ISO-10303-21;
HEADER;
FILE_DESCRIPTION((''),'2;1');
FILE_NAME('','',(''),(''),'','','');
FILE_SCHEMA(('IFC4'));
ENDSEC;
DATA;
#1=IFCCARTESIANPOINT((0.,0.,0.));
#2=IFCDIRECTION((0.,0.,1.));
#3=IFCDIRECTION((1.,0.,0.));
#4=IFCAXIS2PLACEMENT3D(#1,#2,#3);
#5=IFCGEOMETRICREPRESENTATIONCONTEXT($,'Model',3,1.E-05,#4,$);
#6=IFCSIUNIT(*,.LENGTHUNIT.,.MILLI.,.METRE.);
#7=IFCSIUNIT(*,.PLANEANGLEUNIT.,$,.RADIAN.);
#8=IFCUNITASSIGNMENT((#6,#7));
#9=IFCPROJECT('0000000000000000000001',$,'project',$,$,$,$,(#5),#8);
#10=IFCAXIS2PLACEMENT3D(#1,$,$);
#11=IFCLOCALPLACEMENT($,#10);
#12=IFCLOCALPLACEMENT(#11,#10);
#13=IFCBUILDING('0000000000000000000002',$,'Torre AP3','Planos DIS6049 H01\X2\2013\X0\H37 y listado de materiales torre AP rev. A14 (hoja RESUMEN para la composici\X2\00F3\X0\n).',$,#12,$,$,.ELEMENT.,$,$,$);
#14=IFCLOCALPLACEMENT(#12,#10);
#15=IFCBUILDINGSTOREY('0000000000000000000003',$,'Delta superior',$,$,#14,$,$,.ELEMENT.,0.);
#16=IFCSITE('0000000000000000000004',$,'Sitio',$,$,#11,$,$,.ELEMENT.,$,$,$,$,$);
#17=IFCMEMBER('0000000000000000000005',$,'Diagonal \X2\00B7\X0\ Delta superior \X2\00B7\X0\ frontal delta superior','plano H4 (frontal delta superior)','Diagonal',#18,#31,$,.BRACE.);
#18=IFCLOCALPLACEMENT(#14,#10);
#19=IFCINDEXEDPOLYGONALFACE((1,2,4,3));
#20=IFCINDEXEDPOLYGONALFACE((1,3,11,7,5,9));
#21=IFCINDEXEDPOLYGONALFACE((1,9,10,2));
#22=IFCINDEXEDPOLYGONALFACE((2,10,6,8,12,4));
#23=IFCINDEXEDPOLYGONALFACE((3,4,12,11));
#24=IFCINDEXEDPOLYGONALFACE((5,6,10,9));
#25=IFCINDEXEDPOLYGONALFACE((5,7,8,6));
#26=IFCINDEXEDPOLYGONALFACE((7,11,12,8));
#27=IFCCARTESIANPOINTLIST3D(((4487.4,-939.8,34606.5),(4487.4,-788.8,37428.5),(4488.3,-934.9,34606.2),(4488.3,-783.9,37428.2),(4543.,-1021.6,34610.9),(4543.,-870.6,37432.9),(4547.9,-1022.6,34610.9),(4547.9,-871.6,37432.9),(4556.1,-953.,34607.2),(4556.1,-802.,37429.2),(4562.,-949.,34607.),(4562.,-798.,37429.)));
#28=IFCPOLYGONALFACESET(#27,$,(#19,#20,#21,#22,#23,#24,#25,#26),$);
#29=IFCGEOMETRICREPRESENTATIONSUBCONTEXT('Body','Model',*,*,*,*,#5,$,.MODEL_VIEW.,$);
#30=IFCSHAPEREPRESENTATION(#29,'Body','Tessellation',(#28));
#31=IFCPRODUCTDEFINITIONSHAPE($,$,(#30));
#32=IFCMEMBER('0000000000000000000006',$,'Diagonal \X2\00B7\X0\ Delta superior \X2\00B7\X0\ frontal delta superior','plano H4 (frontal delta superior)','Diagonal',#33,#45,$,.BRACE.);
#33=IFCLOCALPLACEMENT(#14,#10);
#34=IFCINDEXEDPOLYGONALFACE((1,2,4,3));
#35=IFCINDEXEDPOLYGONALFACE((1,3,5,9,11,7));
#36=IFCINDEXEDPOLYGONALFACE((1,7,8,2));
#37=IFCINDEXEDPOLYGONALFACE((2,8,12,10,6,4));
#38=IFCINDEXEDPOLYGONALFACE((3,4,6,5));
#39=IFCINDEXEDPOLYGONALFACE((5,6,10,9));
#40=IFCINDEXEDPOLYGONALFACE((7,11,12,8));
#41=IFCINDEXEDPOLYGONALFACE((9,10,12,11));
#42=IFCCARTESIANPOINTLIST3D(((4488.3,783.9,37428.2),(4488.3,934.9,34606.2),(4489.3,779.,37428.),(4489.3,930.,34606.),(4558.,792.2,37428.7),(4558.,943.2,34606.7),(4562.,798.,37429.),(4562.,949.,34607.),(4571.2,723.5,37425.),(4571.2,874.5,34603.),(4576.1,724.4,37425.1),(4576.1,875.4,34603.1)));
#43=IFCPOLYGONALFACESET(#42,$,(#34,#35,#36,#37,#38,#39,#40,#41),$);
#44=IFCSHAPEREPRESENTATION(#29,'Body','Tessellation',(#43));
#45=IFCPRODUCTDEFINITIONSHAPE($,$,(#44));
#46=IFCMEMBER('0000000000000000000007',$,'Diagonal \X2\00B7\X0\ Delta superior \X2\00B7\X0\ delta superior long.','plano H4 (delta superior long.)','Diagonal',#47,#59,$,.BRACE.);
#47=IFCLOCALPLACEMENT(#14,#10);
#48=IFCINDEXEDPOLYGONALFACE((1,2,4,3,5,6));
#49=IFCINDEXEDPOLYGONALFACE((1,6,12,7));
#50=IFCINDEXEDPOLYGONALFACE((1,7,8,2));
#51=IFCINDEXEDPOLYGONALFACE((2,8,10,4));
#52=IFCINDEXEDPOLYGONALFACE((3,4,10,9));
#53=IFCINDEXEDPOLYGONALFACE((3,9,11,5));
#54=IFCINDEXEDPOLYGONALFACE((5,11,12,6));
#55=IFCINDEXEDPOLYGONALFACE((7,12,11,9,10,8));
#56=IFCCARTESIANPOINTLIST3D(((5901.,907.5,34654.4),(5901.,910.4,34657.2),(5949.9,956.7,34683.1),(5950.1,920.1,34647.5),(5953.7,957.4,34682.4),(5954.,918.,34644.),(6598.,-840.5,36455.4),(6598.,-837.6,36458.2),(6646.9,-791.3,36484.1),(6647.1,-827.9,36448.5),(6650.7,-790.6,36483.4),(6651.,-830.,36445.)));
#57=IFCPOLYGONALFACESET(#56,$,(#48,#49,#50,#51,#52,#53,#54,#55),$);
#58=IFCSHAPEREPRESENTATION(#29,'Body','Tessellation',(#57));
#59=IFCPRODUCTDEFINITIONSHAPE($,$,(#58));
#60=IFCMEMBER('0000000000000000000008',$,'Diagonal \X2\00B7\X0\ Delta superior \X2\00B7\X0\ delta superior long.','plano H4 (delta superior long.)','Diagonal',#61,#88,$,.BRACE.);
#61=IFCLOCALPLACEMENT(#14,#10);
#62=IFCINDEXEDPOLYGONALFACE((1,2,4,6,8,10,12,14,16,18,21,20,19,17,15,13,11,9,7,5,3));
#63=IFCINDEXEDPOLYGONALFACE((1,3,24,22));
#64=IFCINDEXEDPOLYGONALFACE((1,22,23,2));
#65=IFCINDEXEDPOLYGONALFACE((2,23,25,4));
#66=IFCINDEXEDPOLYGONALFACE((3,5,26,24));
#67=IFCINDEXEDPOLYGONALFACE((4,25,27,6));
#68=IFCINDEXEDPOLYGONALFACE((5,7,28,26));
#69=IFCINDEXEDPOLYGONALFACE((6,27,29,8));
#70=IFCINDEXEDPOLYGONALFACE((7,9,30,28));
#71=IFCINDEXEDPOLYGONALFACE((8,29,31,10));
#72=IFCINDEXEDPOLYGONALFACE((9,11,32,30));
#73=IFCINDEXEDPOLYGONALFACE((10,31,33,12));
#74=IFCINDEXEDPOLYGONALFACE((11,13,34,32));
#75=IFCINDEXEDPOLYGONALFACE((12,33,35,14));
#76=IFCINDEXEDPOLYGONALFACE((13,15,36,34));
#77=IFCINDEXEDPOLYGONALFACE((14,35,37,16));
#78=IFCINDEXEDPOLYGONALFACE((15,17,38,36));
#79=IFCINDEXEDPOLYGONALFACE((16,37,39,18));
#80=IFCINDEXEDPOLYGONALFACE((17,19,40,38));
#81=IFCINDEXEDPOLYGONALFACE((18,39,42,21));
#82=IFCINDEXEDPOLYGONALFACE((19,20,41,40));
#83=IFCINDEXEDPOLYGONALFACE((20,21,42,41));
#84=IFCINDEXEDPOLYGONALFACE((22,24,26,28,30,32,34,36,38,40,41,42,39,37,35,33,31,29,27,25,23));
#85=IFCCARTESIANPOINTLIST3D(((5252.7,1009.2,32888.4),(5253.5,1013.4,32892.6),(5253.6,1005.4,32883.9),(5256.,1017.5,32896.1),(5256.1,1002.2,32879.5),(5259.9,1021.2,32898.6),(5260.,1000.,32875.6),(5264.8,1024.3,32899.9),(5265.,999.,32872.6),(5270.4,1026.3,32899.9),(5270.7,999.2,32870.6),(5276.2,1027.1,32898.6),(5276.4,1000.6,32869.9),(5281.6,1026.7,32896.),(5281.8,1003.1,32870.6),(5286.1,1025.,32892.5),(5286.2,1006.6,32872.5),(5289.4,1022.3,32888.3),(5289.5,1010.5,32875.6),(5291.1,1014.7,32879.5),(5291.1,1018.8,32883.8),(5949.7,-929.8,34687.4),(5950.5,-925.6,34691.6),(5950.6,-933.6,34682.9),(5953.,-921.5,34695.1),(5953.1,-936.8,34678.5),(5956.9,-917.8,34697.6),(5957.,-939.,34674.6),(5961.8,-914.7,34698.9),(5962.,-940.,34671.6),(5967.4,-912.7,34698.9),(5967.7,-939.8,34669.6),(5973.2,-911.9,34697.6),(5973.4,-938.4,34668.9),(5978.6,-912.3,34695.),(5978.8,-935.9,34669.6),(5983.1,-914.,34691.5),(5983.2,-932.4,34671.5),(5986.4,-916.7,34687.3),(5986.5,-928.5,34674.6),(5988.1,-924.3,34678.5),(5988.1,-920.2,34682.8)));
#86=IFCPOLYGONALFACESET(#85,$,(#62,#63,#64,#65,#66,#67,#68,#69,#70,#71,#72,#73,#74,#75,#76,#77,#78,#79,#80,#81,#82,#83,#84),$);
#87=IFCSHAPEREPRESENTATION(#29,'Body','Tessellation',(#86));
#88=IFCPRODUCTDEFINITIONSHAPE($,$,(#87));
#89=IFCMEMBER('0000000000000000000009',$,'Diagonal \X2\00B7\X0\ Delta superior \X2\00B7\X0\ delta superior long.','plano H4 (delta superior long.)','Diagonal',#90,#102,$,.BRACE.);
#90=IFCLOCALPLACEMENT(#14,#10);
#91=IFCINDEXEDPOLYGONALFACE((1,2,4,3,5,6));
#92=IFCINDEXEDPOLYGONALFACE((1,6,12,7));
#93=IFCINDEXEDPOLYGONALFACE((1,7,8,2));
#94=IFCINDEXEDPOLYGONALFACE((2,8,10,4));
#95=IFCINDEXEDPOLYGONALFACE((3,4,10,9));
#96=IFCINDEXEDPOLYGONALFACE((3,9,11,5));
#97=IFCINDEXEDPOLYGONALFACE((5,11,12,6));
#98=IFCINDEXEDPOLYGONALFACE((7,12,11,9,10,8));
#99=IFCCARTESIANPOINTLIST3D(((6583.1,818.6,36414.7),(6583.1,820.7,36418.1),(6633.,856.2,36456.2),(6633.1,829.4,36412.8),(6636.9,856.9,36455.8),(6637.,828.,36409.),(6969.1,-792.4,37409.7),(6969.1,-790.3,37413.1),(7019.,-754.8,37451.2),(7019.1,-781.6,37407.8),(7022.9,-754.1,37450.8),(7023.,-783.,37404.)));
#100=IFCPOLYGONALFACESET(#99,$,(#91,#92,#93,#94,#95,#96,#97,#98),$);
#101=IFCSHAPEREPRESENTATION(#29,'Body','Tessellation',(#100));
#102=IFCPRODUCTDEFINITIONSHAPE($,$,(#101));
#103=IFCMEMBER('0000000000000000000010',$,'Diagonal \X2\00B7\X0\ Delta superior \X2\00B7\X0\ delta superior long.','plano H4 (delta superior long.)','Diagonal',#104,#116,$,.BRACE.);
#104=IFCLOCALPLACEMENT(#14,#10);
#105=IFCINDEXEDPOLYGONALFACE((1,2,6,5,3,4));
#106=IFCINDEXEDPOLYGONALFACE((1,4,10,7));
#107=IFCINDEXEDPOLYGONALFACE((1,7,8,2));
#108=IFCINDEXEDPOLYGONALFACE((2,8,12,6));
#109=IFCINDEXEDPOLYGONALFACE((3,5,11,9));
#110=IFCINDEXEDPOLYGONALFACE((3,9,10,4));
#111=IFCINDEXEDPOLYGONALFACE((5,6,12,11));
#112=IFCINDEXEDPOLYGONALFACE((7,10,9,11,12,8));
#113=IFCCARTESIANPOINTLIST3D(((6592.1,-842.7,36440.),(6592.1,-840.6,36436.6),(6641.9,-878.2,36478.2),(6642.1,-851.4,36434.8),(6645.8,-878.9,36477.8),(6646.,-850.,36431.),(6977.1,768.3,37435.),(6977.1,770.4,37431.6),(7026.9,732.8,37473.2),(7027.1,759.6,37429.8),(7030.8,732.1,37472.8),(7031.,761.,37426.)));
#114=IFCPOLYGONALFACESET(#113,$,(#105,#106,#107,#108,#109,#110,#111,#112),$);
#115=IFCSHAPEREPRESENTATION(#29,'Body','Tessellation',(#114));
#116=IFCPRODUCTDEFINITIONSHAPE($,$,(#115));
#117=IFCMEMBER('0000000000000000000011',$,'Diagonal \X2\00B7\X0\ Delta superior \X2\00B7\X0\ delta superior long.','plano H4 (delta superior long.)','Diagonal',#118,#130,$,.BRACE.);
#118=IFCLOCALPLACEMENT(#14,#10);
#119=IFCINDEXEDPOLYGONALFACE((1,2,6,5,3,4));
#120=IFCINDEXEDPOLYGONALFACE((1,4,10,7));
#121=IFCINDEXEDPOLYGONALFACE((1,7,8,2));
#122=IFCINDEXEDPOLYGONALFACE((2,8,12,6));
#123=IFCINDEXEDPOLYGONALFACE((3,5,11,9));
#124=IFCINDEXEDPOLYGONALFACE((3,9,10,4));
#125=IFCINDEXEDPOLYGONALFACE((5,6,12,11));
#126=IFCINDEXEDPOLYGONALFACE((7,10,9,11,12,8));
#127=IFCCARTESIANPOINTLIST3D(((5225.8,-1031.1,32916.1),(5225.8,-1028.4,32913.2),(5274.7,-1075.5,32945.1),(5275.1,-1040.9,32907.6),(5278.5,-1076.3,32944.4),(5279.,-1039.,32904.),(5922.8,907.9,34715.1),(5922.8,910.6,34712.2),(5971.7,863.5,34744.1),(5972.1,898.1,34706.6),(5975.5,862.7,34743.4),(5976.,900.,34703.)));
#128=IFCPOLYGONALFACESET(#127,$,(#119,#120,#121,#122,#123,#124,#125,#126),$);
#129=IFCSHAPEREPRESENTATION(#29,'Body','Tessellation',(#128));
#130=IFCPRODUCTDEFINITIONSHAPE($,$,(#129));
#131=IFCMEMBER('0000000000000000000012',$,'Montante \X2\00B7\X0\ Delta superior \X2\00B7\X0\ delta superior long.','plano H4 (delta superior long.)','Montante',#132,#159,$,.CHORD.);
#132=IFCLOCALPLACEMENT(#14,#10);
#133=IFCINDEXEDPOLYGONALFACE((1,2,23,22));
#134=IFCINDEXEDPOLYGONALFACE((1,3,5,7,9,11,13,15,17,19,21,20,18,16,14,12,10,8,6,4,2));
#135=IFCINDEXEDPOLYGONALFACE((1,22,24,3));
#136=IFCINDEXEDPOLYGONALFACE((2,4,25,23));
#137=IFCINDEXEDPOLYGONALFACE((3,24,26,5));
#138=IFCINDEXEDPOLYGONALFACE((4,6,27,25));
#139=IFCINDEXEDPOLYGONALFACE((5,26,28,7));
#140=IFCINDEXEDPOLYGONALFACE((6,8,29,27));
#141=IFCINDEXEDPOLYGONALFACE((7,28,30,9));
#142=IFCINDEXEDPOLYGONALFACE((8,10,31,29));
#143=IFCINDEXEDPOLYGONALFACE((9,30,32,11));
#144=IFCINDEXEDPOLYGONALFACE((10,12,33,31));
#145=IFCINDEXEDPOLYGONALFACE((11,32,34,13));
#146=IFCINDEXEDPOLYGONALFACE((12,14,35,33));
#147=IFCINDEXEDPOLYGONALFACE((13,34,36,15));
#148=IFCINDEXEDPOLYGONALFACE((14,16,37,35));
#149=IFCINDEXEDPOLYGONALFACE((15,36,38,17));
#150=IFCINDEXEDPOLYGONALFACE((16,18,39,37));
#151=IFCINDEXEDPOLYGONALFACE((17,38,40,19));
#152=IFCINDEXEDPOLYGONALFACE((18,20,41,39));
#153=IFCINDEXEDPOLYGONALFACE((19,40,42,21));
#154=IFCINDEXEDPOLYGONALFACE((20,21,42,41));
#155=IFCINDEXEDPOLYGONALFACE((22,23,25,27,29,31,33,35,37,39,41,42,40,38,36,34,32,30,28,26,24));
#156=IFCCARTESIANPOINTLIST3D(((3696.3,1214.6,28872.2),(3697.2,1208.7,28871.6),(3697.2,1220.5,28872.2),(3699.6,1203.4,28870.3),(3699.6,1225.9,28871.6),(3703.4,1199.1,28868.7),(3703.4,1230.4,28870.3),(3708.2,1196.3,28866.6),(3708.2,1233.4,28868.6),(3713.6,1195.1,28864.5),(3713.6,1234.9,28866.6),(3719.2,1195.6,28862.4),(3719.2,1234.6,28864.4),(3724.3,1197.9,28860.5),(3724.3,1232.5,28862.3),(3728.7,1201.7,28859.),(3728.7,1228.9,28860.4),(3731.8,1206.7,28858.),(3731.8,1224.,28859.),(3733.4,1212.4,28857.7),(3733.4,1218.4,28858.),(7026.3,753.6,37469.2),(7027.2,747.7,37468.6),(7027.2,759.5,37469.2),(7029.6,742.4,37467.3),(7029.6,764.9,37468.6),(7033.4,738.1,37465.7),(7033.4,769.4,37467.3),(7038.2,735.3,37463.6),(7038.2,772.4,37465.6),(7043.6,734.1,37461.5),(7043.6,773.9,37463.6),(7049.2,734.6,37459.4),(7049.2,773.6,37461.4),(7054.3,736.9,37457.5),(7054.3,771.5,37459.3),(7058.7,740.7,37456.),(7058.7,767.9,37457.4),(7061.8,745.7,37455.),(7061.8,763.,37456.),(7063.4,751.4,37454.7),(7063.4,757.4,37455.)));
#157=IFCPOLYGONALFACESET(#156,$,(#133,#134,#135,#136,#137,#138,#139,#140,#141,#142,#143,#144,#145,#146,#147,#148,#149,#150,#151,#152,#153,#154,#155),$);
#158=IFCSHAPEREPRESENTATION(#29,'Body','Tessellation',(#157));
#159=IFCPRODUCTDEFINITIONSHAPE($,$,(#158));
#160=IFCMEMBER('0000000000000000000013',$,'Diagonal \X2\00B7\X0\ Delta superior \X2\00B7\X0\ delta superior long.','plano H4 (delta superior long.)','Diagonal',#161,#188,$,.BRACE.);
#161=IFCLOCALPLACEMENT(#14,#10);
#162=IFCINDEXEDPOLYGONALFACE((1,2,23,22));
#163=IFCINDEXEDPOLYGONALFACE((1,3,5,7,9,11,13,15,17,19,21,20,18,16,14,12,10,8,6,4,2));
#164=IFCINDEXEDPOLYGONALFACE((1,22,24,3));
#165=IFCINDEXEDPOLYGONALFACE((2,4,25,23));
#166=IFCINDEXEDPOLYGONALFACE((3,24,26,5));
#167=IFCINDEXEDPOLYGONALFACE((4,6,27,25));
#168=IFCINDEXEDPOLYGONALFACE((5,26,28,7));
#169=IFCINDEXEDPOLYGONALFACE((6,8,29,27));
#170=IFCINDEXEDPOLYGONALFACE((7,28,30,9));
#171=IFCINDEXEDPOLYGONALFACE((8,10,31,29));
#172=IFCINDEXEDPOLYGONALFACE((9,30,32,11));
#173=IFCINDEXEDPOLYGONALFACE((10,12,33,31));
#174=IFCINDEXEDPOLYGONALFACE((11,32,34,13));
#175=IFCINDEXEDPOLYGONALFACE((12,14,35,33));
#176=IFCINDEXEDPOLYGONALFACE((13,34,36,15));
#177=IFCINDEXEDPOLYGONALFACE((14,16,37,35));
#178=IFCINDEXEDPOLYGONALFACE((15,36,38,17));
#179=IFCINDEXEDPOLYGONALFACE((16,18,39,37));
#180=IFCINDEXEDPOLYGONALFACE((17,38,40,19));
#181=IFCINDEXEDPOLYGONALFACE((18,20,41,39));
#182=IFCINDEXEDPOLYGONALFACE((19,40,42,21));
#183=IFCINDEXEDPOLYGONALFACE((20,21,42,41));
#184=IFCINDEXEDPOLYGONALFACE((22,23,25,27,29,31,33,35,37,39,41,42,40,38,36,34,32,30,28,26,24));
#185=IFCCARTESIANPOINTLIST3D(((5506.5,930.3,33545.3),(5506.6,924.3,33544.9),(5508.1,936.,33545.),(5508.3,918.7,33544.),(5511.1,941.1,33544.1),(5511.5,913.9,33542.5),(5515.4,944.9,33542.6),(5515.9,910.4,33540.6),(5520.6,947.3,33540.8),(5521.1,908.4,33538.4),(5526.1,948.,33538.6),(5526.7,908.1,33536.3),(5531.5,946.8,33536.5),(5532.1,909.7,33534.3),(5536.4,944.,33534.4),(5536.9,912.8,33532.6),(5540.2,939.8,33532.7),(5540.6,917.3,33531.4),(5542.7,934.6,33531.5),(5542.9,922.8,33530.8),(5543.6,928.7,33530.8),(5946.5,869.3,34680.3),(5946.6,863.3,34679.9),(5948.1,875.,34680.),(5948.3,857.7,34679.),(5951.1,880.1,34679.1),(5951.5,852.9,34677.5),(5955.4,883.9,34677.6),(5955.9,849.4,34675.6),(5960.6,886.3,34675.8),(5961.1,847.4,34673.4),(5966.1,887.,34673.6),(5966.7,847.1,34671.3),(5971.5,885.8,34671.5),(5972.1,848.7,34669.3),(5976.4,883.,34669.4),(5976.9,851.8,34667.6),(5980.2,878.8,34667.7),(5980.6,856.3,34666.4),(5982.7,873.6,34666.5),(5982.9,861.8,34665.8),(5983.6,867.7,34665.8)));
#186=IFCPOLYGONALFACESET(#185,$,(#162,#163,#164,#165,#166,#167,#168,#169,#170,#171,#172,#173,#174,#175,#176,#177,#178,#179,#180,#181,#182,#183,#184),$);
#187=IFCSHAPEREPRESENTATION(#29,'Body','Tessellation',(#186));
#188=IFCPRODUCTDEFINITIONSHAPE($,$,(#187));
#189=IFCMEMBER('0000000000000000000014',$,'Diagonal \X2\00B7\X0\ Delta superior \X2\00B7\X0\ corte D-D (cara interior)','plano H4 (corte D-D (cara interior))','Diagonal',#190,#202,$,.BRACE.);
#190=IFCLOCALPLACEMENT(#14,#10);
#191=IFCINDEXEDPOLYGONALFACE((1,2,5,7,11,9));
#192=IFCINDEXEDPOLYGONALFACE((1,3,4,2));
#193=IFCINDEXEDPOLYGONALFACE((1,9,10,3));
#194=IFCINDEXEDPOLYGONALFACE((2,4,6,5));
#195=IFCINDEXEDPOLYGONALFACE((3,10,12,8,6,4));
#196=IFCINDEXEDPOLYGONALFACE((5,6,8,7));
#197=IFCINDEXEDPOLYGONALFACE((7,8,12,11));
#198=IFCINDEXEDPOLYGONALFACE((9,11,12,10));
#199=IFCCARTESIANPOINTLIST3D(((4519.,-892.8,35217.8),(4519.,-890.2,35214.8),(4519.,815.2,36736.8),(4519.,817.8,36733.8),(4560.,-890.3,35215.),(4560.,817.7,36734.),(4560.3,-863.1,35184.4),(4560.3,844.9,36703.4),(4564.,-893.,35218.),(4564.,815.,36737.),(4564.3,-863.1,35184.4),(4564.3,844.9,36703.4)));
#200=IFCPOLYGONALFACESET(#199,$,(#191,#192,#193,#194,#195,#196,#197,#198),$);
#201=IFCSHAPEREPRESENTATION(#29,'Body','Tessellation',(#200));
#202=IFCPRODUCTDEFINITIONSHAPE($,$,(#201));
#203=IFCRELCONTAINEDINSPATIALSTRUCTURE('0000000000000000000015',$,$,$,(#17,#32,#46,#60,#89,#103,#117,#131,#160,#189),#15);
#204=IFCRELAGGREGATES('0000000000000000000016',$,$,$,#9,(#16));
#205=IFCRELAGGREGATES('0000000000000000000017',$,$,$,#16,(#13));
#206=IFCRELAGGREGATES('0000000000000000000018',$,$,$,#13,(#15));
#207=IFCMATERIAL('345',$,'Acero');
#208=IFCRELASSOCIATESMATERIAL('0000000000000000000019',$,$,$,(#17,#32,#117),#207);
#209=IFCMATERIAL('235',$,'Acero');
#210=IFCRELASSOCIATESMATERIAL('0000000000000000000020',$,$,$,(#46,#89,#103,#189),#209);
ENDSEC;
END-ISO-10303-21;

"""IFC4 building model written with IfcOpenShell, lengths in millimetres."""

from ifc_helpers import new_model, si_unit, frame, frame_2d, origin, origin_with_axes, place, context, subcontext, project, spatial, circle, l_section, extrude, material, element, save


model = new_model("IFC4")

# Units and contexts
model_context = context("Model", 3, precision=1e-05, world=origin_with_axes())
body_context = subcontext(model_context, "Body", "Model", "MODEL_VIEW")
ifc_project = project(units=[si_unit("LENGTHUNIT", "METRE", prefix="MILLI"), si_unit("PLANEANGLEUNIT", "RADIAN")], contexts=[model_context])

# Site, building, storey
site_placement = place(None, origin())
site = spatial("IfcSite", under=ifc_project, at=site_placement, Name="Sitio", CompositionType="ELEMENT")
building_placement = place(site_placement, origin())
building = spatial("IfcBuilding", under=site, at=building_placement, Name="Torre AP3", Description="Planos DIS6049 H01–H37 y listado de materiales torre AP rev. A14 (hoja RESUMEN para la composición).", CompositionType="ELEMENT")
storey_placement = place(building_placement, origin())
storey = spatial("IfcBuildingStorey", under=building, at=storey_placement, Name="Delta superior", CompositionType="ELEMENT", Elevation=0.0)

# Members
ifc_material_1 = material(Name="235", Category="Acero")
ifc_material_2 = material(Name="345", Category="Acero")
for number, where, z_axis, x_axis, name in (
    (1, (4562.0, -949.0, 34607.0), (0.0, 0.053432, 0.998572), (-0.982208, 0.187529, -0.010034), "Diagonal · Delta superior · frontal delta superior"),
    (2, (4562.0, 949.0, 34607.0), (0.0, -0.053432, 0.998572), (-0.982208, -0.187529, -0.010034), "Diagonal · Delta superior · frontal delta superior"),
):
    element("IfcMember", number, at=place(storey_placement, frame(where, z_axis=z_axis, x_axis=x_axis)), inside=storey, material=ifc_material_2, Name=name, Description="plano H4 (frontal delta superior)", ObjectType="Diagonal", PredefinedType="BRACE", context=body_context, shape_type="SweptSolid", body=[
        extrude(l_section(Depth=75.0, Width=75.0, Thickness=5.0, at=frame_2d((37.5, 37.5))), None, (0.0, 0.0, 1.0), 2826.0),
    ])
member_1_placement = place(storey_placement, frame((6651.0, -830.0, 36445.0), z_axis=(-0.267584, 0.671072, -0.691419), x_axis=(-0.963521, -0.190088, 0.188396)))
element("IfcMember", 3, at=member_1_placement, inside=storey, material=ifc_material_1, Name="Diagonal · Delta superior · delta superior long.", Description="plano H4 (delta superior long.)", ObjectType="Diagonal", PredefinedType="BRACE", context=body_context, shape_type="SweptSolid", body=[
    extrude(l_section(Depth=55.0, Width=55.0, Thickness=4.0, at=frame_2d((27.5, 27.5))), None, (0.0, 0.0, 1.0), 2604.8),
])
member_2_placement = place(storey_placement, frame((5969.0, -926.0, 34684.0), z_axis=(-0.254816, 0.708877, -0.657695), x_axis=(-0.966975, -0.190493, 0.169325)))
element("IfcMember", 4, at=member_2_placement, inside=storey, Name="Diagonal · Delta superior · delta superior long.", Description="plano H4 (delta superior long.)", ObjectType="Diagonal", PredefinedType="BRACE", context=body_context, shape_type="SweptSolid", body=[
    extrude(circle(Radius=20.0), None, (0.0, 0.0, 1.0), 2735.3),
])
member_3_placement = place(storey_placement, frame((7023.0, -783.0, 37404.0), z_axis=(-0.199747, 0.833659, -0.514892), x_axis=(-0.979846, -0.170873, 0.103461)))
element("IfcMember", 5, at=member_3_placement, inside=storey, material=ifc_material_1, Name="Diagonal · Delta superior · delta superior long.", Description="plano H4 (delta superior long.)", ObjectType="Diagonal", PredefinedType="BRACE", context=body_context, shape_type="SweptSolid", body=[
    extrude(l_section(Depth=55.0, Width=55.0, Thickness=4.0, at=frame_2d((27.5, 27.5))), None, (0.0, 0.0, 1.0), 1932.4),
])
member_4_placement = place(storey_placement, frame((6646.0, -850.0, 36431.0), z_axis=(0.19925, 0.833745, 0.514945), x_axis=(-0.979943, 0.171353, 0.101736)))
element("IfcMember", 6, at=member_4_placement, inside=storey, material=ifc_material_1, Name="Diagonal · Delta superior · delta superior long.", Description="plano H4 (delta superior long.)", ObjectType="Diagonal", PredefinedType="BRACE", context=body_context, shape_type="SweptSolid", body=[
    extrude(l_section(Depth=55.0, Width=55.0, Thickness=4.0, at=frame_2d((27.5, 27.5))), None, (0.0, 0.0, 1.0), 1932.2),
])
member_5_placement = place(storey_placement, frame((5279.0, -1039.0, 32904.0), z_axis=(0.254816, 0.708877, 0.657695), x_axis=(-0.966953, 0.192686, 0.166953)))
element("IfcMember", 7, at=member_5_placement, inside=storey, material=ifc_material_2, Name="Diagonal · Delta superior · delta superior long.", Description="plano H4 (delta superior long.)", ObjectType="Diagonal", PredefinedType="BRACE", context=body_context, shape_type="SweptSolid", body=[
    extrude(l_section(Depth=55.0, Width=55.0, Thickness=4.0, at=frame_2d((27.5, 27.5))), None, (0.0, 0.0, 1.0), 2735.3),
])
for number, where, z_axis, x_axis, name in (
    (8, (3715.0, 1215.0, 28865.0), (0.360744, -0.049941, 0.931327), (-0.932665, -0.019317, 0.360227), "Montante · Delta superior · delta superior long."),
):
    element("IfcMember", number, at=place(storey_placement, frame(where, z_axis=z_axis, x_axis=x_axis)), inside=storey, Name=name, Description="plano H4 (delta superior long.)", ObjectType="Montante", PredefinedType="CHORD", context=body_context, shape_type="SweptSolid", body=[
        extrude(circle(Radius=20.0), None, (0.0, 0.0, 1.0), 9230.9),
    ])
member_6_placement = place(storey_placement, frame((5525.0, 928.0, 33538.0), z_axis=(0.361002, -0.050048, 0.931221), x_axis=(-0.919866, -0.183339, 0.346747)))
element("IfcMember", 9, at=member_6_placement, inside=storey, Name="Diagonal · Delta superior · delta superior long.", Description="plano H4 (delta superior long.)", ObjectType="Diagonal", PredefinedType="BRACE", context=body_context, shape_type="SweptSolid", body=[
    extrude(circle(Radius=20.0), None, (0.0, 0.0, 1.0), 1218.8),
])
member_7_placement = place(storey_placement, frame((4564.0, 815.0, 36737.0), z_axis=(0.0, -0.74724, -0.664554), x_axis=(-0.999984, 0.003774, -0.004243)))
element("IfcMember", 10, at=member_7_placement, inside=storey, material=ifc_material_1, Name="Diagonal · Delta superior · corte D-D (cara interior)", Description="plano H4 (corte D-D (cara interior))", ObjectType="Diagonal", PredefinedType="BRACE", context=body_context, shape_type="SweptSolid", body=[
    extrude(l_section(Depth=45.0, Width=45.0, Thickness=4.0, at=frame_2d((22.5, 22.5))), None, (0.0, 0.0, 1.0), 2285.7),
])

save(model, "model.ifc")
